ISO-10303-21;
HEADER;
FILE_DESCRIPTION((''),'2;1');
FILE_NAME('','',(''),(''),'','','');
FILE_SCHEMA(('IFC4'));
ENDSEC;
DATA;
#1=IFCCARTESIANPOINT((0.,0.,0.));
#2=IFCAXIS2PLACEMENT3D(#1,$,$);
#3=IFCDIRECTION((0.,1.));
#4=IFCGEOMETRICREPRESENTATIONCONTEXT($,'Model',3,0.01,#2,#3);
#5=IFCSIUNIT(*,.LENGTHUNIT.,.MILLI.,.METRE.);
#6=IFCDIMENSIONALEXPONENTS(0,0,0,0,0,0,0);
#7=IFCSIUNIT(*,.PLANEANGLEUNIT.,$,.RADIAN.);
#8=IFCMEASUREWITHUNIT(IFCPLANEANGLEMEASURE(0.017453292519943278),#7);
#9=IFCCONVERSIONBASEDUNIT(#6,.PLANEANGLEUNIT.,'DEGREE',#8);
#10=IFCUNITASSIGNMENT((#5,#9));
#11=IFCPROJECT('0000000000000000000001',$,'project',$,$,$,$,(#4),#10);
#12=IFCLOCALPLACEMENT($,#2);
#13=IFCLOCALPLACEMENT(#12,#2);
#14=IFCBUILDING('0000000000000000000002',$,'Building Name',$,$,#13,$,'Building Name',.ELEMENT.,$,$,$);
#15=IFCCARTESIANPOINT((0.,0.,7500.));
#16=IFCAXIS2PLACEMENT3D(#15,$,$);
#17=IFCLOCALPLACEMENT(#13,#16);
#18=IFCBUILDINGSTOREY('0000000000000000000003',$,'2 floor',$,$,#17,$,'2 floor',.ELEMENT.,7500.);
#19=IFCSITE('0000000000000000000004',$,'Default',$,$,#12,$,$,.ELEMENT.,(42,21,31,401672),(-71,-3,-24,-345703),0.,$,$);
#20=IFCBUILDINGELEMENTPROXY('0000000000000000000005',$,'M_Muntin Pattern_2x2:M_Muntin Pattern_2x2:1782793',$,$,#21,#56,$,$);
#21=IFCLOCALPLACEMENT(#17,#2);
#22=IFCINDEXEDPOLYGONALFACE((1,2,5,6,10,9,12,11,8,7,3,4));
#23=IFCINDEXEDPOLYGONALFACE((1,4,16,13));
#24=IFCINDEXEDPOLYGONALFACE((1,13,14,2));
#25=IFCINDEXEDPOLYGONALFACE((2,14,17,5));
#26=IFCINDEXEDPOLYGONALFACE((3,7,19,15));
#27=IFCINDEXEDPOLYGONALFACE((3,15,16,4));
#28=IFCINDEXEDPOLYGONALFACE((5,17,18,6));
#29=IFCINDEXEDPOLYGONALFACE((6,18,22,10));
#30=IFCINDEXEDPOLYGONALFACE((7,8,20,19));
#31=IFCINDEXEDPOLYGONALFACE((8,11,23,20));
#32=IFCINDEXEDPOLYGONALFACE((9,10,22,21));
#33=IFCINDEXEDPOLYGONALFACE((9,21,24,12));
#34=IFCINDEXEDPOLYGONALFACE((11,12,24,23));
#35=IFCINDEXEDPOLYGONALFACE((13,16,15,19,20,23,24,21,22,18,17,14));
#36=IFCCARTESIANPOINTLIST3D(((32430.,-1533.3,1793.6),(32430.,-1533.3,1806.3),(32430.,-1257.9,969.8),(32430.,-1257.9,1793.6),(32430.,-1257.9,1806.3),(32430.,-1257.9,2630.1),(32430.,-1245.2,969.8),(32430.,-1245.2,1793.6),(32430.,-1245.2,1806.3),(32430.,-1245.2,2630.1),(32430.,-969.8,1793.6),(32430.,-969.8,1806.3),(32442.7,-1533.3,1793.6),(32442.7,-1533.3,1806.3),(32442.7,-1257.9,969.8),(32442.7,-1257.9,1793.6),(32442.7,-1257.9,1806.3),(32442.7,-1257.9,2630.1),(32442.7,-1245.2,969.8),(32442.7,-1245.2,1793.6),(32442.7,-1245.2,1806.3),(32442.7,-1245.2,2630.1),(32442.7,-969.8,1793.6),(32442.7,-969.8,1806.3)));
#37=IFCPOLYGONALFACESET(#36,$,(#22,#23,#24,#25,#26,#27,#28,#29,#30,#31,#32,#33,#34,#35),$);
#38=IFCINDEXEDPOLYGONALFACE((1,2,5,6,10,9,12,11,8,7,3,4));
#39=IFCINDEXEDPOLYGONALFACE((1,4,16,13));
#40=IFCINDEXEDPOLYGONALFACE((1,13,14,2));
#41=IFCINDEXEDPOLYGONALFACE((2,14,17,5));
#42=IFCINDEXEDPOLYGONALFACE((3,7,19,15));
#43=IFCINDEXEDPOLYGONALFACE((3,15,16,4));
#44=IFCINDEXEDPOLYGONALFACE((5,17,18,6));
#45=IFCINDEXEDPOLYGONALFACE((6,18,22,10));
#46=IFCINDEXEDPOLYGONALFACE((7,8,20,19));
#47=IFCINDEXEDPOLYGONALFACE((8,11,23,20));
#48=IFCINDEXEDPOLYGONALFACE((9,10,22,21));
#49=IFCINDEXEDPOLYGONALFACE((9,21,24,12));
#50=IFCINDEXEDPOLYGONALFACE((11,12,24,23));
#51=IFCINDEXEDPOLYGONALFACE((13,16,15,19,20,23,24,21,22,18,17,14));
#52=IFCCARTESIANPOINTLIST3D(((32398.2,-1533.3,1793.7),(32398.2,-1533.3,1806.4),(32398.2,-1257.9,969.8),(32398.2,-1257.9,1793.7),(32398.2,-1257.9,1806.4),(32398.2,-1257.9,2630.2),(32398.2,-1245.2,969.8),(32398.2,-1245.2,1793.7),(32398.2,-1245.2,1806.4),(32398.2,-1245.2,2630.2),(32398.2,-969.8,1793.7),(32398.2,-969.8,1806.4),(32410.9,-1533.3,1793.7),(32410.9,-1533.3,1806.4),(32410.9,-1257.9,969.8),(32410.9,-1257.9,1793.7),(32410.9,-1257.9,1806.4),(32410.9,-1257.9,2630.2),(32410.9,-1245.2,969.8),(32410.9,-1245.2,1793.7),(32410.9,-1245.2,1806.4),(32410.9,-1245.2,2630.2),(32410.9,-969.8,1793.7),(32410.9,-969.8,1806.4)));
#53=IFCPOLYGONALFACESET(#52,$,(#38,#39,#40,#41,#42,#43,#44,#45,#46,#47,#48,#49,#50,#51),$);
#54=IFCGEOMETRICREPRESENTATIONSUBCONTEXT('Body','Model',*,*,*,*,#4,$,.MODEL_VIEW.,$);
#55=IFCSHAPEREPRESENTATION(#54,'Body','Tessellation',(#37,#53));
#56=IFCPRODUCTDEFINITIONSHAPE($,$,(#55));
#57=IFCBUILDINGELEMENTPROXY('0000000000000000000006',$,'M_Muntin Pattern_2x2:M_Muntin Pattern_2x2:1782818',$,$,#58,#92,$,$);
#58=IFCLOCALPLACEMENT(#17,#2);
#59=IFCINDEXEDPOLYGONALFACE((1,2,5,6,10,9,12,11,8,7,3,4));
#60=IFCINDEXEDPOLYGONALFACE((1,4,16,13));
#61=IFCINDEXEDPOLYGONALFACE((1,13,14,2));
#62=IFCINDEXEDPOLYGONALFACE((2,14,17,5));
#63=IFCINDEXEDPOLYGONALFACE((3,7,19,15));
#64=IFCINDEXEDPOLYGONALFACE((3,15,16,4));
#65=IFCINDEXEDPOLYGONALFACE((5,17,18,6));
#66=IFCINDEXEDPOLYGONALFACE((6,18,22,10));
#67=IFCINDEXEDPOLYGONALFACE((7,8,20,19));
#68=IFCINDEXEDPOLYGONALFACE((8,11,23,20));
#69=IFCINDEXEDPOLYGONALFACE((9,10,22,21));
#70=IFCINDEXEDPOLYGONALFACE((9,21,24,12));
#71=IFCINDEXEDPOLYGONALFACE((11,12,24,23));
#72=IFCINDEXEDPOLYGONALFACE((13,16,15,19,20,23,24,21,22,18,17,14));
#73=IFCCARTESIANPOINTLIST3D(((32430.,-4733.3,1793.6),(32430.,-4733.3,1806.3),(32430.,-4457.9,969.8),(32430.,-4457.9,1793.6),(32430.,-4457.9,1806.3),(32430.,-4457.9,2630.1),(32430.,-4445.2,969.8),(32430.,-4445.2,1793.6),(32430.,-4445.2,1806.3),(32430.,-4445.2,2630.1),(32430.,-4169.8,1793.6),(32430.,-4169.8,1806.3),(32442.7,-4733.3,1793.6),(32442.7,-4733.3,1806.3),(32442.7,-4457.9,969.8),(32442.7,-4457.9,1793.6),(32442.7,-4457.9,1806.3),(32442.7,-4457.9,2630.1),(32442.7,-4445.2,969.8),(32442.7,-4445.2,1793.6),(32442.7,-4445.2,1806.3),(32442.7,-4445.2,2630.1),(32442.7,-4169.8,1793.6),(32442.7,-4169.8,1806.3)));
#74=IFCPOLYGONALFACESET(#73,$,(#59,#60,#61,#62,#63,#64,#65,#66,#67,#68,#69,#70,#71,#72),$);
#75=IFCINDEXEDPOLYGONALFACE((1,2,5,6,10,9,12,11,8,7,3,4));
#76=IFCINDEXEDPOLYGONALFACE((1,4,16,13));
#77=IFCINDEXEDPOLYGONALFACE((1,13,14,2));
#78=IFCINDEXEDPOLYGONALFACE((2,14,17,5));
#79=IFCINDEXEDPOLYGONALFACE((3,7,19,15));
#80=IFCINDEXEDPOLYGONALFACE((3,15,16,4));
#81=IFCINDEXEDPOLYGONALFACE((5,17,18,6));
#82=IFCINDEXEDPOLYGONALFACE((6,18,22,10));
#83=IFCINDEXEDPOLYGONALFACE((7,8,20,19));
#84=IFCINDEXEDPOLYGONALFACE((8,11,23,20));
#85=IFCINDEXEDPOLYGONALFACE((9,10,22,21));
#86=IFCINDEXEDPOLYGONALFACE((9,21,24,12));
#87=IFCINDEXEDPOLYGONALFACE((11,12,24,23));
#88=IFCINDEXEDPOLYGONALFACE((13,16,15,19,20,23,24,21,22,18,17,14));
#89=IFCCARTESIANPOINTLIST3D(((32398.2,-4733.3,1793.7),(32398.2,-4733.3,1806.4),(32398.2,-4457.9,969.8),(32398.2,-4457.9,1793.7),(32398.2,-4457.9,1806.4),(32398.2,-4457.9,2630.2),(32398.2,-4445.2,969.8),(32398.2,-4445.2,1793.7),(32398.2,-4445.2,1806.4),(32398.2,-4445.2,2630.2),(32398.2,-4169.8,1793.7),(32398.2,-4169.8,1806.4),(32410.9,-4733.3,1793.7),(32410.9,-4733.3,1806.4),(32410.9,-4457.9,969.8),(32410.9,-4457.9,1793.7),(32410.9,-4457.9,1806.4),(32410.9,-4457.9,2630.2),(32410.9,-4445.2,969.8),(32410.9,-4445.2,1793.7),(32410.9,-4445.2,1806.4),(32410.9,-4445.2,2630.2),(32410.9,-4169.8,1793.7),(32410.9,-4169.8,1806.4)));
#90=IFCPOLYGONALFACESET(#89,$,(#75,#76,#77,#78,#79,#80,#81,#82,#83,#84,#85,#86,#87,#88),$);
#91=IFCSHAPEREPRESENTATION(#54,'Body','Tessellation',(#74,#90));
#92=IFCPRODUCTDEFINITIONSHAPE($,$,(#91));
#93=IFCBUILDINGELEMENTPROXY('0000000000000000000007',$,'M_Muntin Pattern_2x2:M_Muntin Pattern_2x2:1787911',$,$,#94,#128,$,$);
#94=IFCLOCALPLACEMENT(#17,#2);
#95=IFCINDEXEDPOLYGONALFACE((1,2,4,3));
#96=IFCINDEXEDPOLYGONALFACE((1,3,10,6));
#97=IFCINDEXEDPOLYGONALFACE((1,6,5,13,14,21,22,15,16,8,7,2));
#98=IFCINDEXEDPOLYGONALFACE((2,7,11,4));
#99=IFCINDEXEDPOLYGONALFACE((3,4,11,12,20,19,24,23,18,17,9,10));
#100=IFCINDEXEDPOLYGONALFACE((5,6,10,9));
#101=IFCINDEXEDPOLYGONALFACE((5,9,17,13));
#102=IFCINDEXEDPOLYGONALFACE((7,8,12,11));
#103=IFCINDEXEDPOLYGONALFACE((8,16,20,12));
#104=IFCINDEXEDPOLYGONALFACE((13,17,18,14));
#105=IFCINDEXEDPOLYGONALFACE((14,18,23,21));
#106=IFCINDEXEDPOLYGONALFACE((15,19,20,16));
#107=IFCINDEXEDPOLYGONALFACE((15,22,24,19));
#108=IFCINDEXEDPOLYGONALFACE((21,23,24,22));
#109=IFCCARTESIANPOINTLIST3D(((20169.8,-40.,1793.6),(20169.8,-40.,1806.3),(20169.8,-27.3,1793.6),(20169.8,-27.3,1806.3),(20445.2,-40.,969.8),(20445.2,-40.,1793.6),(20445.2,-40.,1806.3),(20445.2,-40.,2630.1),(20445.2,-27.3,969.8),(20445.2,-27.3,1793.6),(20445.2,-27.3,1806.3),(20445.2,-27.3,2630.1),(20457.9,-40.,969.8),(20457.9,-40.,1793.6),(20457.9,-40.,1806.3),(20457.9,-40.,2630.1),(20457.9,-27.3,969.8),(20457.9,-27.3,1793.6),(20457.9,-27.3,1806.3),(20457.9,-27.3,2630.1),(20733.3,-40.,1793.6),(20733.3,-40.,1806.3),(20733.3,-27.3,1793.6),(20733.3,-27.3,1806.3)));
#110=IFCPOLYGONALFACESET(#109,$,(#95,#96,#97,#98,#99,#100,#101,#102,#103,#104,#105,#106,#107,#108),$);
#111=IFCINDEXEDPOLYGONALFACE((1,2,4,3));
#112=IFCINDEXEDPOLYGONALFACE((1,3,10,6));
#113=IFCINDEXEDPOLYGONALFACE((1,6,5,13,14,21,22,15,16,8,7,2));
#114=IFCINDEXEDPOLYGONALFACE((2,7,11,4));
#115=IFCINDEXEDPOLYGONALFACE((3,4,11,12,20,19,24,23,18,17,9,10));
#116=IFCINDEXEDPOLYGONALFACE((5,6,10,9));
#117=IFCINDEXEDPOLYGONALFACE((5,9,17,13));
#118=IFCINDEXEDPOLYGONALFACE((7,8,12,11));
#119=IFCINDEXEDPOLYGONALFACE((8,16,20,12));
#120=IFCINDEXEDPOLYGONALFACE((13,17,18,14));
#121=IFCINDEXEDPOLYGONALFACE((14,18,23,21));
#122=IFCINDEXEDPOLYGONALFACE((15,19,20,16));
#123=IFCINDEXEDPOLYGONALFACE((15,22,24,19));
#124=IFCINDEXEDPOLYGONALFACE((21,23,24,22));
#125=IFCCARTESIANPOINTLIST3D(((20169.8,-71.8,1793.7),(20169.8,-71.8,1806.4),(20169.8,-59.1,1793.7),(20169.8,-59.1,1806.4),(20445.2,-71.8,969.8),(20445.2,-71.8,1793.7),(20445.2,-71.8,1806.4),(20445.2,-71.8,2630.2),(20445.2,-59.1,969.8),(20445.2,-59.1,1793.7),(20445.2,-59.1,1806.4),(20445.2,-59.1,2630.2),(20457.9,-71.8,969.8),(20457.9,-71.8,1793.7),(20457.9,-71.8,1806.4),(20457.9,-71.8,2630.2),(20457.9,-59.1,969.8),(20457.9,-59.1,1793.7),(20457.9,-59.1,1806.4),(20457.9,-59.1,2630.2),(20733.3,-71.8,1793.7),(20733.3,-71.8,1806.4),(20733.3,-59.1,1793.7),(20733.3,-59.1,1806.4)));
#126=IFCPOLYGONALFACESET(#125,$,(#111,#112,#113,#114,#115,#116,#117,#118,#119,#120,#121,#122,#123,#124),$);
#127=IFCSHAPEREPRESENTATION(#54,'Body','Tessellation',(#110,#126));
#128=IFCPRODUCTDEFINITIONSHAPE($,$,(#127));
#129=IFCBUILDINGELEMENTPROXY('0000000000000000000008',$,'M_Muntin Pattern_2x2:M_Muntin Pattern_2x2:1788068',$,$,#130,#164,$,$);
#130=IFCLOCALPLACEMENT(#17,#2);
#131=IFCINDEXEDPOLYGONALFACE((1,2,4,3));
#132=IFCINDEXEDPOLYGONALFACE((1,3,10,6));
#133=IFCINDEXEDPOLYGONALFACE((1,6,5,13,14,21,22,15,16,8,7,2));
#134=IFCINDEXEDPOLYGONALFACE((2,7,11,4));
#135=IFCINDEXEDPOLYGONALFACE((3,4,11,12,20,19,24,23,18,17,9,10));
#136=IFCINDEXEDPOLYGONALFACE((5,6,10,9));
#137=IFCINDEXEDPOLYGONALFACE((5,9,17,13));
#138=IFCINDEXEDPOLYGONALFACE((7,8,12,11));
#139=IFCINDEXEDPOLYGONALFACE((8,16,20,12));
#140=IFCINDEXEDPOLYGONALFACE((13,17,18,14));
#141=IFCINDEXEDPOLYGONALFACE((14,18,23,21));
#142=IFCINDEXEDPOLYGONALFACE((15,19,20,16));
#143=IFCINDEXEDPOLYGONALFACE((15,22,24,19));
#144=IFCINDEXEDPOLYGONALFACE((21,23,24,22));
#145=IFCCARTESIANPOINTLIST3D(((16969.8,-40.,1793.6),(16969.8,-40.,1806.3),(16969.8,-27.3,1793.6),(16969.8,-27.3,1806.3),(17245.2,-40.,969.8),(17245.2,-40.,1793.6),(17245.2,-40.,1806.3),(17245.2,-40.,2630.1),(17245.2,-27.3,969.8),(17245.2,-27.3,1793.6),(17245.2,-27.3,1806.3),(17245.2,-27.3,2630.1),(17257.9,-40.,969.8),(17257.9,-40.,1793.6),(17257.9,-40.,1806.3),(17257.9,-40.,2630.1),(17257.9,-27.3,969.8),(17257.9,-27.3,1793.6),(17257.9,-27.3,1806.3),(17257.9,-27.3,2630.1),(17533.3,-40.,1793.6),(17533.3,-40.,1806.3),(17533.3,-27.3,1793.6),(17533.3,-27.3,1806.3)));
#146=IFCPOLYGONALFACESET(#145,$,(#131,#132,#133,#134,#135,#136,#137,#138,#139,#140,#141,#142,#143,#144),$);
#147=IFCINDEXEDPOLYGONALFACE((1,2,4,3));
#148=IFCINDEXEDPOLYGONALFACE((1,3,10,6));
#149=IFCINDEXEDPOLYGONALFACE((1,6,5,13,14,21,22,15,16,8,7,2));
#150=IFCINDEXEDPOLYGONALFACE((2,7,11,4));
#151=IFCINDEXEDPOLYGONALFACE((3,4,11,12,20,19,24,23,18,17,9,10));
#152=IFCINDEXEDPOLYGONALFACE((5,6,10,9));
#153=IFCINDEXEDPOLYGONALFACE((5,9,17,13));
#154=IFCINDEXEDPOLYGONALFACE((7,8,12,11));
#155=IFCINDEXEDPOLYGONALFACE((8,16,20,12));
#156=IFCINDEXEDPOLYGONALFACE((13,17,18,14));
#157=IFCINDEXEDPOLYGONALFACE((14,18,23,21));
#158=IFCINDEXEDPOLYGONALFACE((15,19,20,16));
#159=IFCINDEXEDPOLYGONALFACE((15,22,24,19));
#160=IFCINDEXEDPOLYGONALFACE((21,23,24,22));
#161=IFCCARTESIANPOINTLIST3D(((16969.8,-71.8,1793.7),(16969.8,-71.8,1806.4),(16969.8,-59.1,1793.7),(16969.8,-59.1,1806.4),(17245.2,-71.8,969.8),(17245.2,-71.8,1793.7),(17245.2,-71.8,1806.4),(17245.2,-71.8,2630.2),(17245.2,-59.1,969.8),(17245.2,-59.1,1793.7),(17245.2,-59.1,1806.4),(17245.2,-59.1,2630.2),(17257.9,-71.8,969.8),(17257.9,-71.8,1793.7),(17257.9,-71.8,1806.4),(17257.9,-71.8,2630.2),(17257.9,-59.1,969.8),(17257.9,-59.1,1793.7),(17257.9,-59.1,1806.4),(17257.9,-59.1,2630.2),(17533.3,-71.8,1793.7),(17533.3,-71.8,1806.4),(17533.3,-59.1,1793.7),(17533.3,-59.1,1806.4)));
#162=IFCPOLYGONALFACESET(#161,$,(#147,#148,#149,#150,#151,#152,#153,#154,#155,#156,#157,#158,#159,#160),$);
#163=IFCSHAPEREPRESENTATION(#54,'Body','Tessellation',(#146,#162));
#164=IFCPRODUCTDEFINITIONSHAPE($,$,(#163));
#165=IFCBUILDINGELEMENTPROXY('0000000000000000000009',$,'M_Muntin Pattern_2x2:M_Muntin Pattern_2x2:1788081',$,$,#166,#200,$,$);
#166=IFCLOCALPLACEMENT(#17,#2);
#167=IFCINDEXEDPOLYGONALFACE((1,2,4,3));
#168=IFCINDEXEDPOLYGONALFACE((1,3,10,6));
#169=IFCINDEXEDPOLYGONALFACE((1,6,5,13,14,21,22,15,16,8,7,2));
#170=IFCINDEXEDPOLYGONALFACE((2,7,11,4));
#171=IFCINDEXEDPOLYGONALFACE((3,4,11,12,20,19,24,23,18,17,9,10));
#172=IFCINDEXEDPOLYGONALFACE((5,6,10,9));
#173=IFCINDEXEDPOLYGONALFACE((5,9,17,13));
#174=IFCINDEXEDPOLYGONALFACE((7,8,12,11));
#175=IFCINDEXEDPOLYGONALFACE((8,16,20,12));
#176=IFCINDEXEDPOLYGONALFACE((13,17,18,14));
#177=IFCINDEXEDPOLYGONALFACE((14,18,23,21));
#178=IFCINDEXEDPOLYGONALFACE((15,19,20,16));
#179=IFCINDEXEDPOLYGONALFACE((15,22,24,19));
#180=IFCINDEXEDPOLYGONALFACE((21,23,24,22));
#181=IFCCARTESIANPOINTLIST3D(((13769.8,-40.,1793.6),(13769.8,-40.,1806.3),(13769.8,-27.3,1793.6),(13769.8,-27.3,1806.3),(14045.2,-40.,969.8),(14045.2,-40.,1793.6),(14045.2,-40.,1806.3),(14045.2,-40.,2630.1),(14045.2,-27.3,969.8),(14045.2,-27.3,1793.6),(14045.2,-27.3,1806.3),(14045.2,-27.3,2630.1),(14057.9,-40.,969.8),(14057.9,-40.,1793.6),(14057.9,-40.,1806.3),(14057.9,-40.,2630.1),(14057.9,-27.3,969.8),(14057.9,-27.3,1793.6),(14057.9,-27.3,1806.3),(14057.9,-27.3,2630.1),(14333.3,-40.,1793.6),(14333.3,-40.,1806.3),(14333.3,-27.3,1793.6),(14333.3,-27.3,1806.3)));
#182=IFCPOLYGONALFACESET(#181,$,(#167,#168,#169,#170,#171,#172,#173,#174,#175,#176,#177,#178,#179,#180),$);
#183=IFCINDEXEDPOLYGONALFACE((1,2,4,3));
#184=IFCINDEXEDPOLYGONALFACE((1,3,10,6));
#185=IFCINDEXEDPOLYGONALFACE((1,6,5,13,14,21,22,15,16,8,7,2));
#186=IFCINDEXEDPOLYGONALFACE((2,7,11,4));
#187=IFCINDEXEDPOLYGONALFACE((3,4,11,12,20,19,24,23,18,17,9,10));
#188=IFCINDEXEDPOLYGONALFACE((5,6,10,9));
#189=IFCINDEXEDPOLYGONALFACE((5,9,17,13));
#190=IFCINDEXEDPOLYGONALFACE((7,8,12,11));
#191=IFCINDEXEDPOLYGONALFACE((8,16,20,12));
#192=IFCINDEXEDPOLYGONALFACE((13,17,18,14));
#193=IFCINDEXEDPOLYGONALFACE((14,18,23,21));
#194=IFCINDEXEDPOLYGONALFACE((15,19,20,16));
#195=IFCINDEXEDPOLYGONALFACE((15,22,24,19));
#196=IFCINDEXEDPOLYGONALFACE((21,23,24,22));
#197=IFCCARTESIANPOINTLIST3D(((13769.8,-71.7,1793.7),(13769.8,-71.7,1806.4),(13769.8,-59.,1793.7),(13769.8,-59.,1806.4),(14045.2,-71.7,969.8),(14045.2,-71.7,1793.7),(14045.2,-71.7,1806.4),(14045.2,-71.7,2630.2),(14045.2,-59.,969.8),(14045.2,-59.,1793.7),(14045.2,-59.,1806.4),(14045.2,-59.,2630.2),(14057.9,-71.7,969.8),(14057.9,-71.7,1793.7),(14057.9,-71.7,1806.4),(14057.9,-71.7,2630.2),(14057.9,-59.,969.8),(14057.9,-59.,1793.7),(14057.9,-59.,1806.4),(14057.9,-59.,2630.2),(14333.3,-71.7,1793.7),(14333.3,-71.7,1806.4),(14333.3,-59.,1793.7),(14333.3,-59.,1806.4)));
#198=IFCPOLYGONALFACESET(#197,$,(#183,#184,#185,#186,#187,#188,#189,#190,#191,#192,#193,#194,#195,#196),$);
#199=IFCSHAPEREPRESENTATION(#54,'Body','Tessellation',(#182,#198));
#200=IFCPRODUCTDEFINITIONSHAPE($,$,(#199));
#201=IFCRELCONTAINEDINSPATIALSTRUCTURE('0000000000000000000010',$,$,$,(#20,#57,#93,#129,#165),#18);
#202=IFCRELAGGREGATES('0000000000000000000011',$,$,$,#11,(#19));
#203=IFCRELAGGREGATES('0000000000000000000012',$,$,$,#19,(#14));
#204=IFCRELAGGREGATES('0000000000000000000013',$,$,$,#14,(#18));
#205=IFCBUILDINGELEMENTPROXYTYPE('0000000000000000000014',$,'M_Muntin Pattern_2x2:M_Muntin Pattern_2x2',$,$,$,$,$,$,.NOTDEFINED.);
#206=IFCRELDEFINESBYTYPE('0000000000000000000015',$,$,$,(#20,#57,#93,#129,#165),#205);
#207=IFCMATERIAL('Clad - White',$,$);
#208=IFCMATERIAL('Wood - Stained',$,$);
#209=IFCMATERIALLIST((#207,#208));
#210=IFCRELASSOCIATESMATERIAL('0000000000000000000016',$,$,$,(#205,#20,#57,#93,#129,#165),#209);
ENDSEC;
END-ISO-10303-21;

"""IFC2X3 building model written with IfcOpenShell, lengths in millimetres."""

from ifc_helpers import new_model, entity, si_unit, converted_unit, direction, frame, origin, place, context, subcontext, project, spatial, polyline, outline, extrude, source, transform, mapped, material, material_list, type_object, type_shapes, element, save


model = new_model("IFC2X3")

# Units and contexts
model_context = context("Model", 3, precision=0.01, world=origin(), true_north=direction((0.0, 1.0)))
body_context = subcontext(model_context, "Body", "Model", "MODEL_VIEW")
ifc_project = project(units=[si_unit("LENGTHUNIT", "METRE", prefix="MILLI"), converted_unit("PLANEANGLEUNIT", "DEGREE", entity("IfcPlaneAngleMeasure", 0.017453292519943278), si_unit("PLANEANGLEUNIT", "RADIAN"), dimensions=[0, 0, 0, 0, 0, 0, 0])], contexts=[model_context])

# Site, building, storey
site_placement = place(None, origin())
site = spatial("IfcSite", under=ifc_project, at=site_placement, Name="Default", CompositionType="ELEMENT", RefLatitude=(42, 21, 31, 401672), RefLongitude=(-71, -3, -24, -345703), RefElevation=0.0)
building_placement = place(site_placement, origin())
building = spatial("IfcBuilding", under=site, at=building_placement, Name="Building Name", LongName="Building Name", CompositionType="ELEMENT")
storey_placement = place(building_placement, frame((0.0, 0.0, 7500.0)))
storey = spatial("IfcBuildingStorey", under=building, at=storey_placement, Name="2 floor", LongName="2 floor", CompositionType="ELEMENT", Elevation=7500.0)

# Building element proxies
ifc_material_1 = material(Name="Clad - White")
ifc_material_2 = material(Name="Wood - Stained")
ifc_material_list = material_list([ifc_material_1, ifc_material_2])
building_element_proxy_type_1 = type_object("IfcBuildingElementProxyType", Name="M_Muntin Pattern_2x2:M_Muntin Pattern_2x2", PredefinedType="NOTDEFINED", material=ifc_material_list)
shared_shape_1 = source(origin(), body_context, "Body", "SweptSolid", [
    extrude(outline(polyline([(6.4, -6.4), (830.1, -6.4), (830.1, 6.3), (6.4, 6.3), (6.4, 281.7), (-6.3, 281.7), (-6.3, 6.3), (-830.2, 6.3), (-830.2, -6.4), (-6.3, -6.4), (-6.3, -281.7), (6.4, -281.7), (6.4, -6.4)])), frame((0.0, 9.5, 830.1), z_axis=(0.0, 1.0, 0.0), x_axis=(0.0, 0.0, 1.0)), (0.0, 0.0, 1.0), 12.7),
    extrude(outline(polyline([(6.4, -6.4), (830.2, -6.4), (830.2, 6.3), (6.4, 6.3), (6.4, 281.7), (-6.3, 281.7), (-6.3, 6.3), (-830.2, 6.3), (-830.2, -6.4), (-6.3, -6.4), (-6.3, -281.7), (6.4, -281.7), (6.4, -6.4)])), frame((0.0, -22.2, 830.2), z_axis=(0.0, 1.0, 0.0), x_axis=(0.0, 0.0, 1.0)), (0.0, 0.0, 1.0), 12.7),
])
type_shapes(building_element_proxy_type_1, [shared_shape_1])
for number, where, z_axis, x_axis, name in (
    (1, (32420.5, -1251.6, 969.8), (0.0, 0.0, 1.0), (0.0, -1.0, 0.0), "M_Muntin Pattern_2x2:M_Muntin Pattern_2x2:1782793"),
    (2, (32420.5, -4451.6, 969.8), (0.0, 0.0, 1.0), (0.0, -1.0, 0.0), "M_Muntin Pattern_2x2:M_Muntin Pattern_2x2:1782818"),
):
    element("IfcBuildingElementProxy", number, at=place(storey_placement, frame(where, z_axis=z_axis, x_axis=x_axis)), inside=storey, type_object=building_element_proxy_type_1, material=ifc_material_list, Name=name, context=body_context, shape_type="MappedRepresentation", body=[
        mapped(shared_shape_1, transform((0.0, 0.0, 0.0), scale=1.0)),
    ])
for number, where, name in (
    (3, (20451.6, -49.5, 969.8), "M_Muntin Pattern_2x2:M_Muntin Pattern_2x2:1787911"),
    (4, (17251.6, -49.5, 969.8), "M_Muntin Pattern_2x2:M_Muntin Pattern_2x2:1788068"),
    (5, (14051.6, -49.5, 969.8), "M_Muntin Pattern_2x2:M_Muntin Pattern_2x2:1788081"),
):
    element("IfcBuildingElementProxy", number, at=place(storey_placement, frame(where)), inside=storey, type_object=building_element_proxy_type_1, material=ifc_material_list, Name=name, context=body_context, shape_type="MappedRepresentation", body=[
        mapped(shared_shape_1, transform((0.0, 0.0, 0.0), scale=1.0)),
    ])

save(model, "model.ifc")
